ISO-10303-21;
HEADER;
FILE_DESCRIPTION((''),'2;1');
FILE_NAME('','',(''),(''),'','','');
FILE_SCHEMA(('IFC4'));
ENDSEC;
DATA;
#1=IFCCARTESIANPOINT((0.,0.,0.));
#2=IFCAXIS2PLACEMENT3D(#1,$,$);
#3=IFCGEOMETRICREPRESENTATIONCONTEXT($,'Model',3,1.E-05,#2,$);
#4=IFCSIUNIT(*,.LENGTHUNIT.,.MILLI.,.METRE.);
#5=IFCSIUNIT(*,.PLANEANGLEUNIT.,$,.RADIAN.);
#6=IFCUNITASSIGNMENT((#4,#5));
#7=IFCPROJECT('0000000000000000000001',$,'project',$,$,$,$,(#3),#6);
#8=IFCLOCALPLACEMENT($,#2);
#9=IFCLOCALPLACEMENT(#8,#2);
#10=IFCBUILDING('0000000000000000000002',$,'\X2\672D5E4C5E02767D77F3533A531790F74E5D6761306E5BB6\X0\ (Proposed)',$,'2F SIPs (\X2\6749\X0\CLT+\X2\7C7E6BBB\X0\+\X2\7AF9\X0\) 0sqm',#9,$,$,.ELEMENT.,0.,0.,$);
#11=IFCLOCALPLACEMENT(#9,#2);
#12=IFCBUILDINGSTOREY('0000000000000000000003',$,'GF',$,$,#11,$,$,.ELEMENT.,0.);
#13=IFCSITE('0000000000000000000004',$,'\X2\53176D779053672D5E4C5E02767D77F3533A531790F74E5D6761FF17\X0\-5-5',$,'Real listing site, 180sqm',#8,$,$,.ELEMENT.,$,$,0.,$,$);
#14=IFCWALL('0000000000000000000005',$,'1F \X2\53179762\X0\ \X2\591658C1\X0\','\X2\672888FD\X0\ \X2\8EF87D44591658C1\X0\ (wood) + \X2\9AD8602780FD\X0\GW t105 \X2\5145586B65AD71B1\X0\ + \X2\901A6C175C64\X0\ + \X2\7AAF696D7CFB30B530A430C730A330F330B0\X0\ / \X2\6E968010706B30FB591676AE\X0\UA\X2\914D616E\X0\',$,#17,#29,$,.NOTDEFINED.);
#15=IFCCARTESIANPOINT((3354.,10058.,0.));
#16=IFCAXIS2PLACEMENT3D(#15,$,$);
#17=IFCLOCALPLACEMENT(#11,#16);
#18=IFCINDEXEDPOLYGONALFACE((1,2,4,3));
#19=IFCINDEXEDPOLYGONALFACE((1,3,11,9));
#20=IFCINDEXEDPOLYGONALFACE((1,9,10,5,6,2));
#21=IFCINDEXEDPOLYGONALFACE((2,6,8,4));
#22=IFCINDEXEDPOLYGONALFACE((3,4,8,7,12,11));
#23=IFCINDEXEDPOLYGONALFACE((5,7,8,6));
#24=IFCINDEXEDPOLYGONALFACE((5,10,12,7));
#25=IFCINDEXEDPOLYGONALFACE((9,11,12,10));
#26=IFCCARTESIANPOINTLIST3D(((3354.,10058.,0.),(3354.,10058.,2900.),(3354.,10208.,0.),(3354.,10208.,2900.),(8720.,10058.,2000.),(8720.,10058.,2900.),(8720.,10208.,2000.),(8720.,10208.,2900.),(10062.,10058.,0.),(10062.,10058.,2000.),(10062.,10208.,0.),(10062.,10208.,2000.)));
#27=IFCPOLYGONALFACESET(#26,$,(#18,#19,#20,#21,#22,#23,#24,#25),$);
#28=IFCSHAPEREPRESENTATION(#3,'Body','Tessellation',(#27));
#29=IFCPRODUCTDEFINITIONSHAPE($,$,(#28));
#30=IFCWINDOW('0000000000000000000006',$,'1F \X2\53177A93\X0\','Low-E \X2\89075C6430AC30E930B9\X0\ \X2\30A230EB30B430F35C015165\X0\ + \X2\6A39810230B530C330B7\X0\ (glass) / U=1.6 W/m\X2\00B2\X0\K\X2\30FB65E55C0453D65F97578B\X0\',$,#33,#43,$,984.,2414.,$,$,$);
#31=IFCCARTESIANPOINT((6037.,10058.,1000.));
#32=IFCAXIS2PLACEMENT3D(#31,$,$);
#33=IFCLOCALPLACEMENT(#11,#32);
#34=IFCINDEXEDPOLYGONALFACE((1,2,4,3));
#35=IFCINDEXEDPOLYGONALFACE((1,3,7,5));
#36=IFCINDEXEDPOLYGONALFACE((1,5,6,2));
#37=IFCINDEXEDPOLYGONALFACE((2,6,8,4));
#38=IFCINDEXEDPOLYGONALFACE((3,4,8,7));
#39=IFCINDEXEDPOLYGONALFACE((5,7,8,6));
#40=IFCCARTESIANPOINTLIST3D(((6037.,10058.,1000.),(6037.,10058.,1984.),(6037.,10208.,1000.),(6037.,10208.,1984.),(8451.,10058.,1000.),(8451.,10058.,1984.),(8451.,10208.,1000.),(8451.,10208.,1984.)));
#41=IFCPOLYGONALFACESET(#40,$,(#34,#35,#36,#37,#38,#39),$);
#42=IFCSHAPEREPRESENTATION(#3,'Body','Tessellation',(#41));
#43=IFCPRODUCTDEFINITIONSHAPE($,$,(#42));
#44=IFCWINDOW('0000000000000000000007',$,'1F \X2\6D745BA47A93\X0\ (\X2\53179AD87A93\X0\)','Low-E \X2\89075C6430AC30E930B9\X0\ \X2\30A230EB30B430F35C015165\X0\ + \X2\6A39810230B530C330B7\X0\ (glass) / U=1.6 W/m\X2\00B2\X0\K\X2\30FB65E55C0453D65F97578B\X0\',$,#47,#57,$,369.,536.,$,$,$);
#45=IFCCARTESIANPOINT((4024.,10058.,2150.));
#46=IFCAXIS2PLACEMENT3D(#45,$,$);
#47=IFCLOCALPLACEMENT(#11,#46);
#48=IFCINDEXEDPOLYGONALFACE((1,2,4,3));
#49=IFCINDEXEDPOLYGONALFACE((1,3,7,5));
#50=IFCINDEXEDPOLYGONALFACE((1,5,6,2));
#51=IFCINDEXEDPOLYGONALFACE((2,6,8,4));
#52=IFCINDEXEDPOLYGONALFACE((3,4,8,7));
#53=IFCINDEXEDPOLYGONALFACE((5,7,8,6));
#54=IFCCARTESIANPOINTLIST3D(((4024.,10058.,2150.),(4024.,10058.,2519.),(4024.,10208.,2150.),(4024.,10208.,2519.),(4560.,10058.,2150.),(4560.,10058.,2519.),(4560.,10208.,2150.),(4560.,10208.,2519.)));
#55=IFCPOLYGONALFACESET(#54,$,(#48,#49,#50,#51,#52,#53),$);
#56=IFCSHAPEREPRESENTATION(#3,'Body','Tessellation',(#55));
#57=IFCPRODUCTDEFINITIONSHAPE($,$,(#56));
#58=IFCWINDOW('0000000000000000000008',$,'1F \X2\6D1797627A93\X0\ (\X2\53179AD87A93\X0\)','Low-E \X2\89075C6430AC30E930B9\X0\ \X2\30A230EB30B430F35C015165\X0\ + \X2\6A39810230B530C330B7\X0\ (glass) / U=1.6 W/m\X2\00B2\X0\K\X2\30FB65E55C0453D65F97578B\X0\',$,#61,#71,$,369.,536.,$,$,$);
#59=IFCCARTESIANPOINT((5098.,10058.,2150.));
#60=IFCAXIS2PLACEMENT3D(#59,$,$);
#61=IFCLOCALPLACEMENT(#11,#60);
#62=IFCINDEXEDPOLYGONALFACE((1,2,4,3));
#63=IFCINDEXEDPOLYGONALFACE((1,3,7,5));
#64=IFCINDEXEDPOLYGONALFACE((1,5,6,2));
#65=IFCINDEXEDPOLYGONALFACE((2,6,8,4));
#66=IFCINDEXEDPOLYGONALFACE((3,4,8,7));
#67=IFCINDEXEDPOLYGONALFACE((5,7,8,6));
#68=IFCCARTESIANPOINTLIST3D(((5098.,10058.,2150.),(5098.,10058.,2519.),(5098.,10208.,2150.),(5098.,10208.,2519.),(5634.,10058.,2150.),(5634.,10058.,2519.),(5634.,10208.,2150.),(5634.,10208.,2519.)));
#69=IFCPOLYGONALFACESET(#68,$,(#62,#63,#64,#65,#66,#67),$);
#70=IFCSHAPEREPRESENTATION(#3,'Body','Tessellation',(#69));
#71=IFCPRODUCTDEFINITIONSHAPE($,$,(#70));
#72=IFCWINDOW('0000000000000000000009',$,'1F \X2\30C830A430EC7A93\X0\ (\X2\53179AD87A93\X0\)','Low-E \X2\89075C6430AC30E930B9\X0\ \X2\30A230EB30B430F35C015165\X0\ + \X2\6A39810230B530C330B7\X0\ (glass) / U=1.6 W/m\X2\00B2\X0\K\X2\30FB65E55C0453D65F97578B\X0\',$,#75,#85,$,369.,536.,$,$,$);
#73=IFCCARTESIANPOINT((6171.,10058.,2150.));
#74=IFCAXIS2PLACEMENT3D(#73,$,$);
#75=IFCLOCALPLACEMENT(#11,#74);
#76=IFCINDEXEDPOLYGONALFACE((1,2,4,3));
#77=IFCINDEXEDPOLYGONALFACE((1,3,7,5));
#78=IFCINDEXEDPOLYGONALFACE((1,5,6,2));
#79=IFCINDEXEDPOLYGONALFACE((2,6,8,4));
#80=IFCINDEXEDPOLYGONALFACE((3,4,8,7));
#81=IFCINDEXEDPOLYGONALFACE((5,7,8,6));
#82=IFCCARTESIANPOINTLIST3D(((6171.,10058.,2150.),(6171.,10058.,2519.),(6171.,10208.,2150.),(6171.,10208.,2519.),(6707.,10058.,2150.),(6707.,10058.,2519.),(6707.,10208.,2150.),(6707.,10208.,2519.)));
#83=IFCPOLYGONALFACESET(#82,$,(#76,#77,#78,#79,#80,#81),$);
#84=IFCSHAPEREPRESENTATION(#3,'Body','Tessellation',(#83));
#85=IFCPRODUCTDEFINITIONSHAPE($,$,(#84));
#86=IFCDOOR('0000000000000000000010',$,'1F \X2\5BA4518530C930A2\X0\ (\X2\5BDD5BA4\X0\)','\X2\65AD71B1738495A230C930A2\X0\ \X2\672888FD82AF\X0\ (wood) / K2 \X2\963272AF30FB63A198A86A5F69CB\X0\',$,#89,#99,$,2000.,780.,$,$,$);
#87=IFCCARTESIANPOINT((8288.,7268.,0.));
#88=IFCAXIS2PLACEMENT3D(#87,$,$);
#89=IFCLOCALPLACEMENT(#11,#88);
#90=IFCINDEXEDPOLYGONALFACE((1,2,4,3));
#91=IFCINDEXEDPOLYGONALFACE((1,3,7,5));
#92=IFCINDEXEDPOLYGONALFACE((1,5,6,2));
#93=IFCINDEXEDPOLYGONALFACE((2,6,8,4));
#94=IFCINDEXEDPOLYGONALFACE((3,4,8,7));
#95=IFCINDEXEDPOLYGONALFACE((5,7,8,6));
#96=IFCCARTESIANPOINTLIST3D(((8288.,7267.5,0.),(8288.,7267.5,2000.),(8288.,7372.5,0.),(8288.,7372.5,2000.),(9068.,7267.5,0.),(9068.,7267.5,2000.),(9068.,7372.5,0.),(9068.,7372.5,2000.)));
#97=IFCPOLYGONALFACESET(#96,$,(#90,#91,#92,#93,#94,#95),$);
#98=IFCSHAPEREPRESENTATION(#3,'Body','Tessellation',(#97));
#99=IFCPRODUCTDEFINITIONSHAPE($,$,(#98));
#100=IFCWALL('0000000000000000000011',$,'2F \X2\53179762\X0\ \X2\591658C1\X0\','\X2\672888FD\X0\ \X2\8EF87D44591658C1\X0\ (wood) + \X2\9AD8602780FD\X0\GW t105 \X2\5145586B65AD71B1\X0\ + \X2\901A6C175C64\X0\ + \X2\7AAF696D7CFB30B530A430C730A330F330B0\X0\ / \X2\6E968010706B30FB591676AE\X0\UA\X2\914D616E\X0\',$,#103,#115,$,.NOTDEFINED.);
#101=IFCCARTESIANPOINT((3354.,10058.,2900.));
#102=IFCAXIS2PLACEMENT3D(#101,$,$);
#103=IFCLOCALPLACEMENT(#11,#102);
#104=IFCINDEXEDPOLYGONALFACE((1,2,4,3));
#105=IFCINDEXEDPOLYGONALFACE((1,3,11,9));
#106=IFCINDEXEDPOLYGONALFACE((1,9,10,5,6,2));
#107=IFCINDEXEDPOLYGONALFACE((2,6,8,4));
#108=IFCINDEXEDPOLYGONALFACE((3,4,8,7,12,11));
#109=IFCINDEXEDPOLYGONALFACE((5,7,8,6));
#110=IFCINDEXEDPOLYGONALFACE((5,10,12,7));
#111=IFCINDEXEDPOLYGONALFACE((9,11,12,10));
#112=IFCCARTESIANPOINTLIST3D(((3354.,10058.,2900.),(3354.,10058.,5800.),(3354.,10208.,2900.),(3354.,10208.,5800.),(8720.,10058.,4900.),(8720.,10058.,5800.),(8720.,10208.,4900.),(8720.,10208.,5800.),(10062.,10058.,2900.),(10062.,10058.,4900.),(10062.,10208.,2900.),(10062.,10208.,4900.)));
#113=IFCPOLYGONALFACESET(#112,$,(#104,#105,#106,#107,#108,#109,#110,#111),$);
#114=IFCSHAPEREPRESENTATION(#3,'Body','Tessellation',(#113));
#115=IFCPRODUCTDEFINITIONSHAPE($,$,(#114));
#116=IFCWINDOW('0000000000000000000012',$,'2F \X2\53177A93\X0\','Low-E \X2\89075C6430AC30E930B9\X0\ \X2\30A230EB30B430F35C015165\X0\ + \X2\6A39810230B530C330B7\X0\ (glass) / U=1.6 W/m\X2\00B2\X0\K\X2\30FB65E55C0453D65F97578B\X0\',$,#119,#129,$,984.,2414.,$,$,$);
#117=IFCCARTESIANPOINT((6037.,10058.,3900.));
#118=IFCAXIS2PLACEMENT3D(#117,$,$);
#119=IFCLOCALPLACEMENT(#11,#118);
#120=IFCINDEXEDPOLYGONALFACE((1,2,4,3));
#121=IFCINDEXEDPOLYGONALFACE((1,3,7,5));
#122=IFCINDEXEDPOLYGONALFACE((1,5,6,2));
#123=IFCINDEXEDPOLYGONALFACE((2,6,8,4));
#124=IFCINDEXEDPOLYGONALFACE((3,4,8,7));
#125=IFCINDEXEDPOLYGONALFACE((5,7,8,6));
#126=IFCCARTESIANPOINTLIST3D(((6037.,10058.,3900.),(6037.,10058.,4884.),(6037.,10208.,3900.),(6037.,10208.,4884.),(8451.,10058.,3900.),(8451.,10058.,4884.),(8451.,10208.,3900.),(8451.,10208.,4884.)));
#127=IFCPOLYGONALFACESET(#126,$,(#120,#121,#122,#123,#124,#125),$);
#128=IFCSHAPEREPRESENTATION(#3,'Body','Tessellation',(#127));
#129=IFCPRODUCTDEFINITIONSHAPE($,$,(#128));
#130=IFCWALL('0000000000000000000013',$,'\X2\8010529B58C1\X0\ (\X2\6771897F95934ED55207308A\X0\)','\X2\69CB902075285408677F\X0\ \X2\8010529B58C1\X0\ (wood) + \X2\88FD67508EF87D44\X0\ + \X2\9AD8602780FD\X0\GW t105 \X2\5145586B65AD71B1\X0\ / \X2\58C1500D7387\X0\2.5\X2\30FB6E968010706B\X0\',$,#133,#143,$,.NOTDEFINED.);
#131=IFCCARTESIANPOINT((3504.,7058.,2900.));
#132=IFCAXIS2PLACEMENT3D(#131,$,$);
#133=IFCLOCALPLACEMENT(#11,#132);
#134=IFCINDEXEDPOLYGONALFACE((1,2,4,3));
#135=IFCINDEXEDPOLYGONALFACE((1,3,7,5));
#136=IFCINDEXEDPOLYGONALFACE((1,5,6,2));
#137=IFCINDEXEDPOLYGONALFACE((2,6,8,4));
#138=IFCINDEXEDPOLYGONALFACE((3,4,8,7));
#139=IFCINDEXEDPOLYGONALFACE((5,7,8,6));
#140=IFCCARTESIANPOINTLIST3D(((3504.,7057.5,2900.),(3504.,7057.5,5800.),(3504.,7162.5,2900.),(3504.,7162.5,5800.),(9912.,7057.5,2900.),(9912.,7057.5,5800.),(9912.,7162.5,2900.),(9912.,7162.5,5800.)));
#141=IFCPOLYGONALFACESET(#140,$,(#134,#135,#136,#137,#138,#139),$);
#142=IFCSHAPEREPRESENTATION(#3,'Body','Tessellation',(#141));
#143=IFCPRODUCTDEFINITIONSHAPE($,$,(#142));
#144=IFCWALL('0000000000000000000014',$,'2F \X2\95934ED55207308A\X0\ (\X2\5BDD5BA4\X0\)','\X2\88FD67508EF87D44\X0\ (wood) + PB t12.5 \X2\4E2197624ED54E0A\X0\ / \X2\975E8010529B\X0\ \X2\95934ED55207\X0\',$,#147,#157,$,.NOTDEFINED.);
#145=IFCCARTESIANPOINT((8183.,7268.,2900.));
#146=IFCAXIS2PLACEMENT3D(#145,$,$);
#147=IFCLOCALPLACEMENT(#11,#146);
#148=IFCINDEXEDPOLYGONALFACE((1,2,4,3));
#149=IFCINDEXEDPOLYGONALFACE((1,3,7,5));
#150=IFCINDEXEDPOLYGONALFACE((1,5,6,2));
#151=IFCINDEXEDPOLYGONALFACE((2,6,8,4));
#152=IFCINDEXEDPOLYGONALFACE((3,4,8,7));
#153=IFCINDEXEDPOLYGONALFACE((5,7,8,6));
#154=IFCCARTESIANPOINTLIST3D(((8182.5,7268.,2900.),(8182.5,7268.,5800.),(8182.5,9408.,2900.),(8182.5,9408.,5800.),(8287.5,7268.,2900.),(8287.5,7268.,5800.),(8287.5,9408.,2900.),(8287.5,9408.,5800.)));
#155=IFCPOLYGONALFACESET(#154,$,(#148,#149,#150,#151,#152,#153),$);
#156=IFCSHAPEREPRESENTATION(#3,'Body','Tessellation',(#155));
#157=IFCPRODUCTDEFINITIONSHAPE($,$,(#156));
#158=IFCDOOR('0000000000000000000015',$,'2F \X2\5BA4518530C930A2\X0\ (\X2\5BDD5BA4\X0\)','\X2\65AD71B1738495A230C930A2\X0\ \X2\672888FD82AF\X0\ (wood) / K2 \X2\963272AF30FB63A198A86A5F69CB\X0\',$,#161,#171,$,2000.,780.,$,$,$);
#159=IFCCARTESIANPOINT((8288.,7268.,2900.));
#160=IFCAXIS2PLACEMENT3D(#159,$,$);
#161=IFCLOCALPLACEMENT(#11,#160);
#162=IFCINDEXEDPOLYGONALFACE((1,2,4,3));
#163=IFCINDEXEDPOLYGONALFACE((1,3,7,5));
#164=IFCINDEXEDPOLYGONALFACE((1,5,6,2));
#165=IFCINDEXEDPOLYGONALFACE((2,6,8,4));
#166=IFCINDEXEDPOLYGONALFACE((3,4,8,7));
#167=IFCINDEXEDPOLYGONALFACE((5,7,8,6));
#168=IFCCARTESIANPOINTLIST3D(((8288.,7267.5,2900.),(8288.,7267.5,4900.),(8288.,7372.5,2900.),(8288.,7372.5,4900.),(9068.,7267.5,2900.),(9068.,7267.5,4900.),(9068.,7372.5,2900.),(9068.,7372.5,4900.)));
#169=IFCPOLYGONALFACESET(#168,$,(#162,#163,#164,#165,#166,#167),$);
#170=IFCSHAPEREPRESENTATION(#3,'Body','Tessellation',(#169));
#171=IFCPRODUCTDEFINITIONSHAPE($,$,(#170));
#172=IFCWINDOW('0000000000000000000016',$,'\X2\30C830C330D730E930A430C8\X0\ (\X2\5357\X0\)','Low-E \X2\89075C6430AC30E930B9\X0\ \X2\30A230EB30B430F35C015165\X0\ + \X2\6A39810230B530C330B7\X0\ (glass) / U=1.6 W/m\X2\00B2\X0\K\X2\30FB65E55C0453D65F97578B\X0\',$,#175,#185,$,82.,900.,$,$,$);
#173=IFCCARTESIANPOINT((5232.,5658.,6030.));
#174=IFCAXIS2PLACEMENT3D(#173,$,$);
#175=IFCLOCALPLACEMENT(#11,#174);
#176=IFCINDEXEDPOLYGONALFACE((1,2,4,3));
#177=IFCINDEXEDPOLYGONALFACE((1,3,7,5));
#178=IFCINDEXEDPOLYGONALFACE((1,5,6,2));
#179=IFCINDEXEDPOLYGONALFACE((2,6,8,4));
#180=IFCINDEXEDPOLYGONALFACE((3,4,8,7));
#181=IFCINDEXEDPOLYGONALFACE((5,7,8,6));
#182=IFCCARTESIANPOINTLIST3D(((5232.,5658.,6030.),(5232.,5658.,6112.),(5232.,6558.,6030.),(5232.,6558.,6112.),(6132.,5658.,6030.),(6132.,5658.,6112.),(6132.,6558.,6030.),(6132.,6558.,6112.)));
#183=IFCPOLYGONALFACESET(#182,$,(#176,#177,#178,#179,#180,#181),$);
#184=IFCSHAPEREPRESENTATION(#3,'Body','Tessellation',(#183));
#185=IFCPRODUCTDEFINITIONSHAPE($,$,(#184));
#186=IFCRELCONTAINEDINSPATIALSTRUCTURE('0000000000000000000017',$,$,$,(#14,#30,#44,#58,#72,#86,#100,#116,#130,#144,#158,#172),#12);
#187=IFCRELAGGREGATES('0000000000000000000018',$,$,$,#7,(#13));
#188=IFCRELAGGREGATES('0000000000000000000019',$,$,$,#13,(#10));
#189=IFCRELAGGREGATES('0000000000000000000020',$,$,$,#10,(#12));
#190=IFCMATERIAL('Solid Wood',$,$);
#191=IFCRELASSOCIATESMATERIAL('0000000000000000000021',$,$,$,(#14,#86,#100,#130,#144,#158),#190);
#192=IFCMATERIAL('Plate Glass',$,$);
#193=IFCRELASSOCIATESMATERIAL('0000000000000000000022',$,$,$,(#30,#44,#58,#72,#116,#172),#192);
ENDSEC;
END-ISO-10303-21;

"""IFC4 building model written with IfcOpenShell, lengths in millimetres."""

from ifc_helpers import new_model, si_unit, frame, frame_2d, origin, place, context, project, spatial, rectangle, extrude, material, element, fill, save


model = new_model("IFC4")

# Units and contexts
model_context = context("Model", 3, precision=1e-05, world=origin())
ifc_project = project(units=[si_unit("LENGTHUNIT", "METRE", prefix="MILLI"), si_unit("PLANEANGLEUNIT", "RADIAN")], contexts=[model_context])

# Site, building, storey
site_placement = place(None, origin())
site = spatial("IfcSite", under=ifc_project, at=site_placement, Name="北海道札幌市白石区北郷九条７-5-5", ObjectType="Real listing site, 180sqm", CompositionType="ELEMENT", RefElevation=0.0)
building_placement = place(site_placement, origin())
building = spatial("IfcBuilding", under=site, at=building_placement, Name="札幌市白石区北郷九条の家 (Proposed)", ObjectType="2F SIPs (杉CLT+籾殻+竹) 0sqm", CompositionType="ELEMENT", ElevationOfRefHeight=0.0, ElevationOfTerrain=0.0)
storey_placement = place(building_placement, origin())
storey = spatial("IfcBuildingStorey", under=building, at=storey_placement, Name="GF", CompositionType="ELEMENT", Elevation=0.0)

# Wall, openings, windows
ifc_material_1 = material(Name="Solid Wood")
wall_1_placement = place(storey_placement, frame((3354.0, 10058.0, 0.0)))
wall_1 = element("IfcWall", 1, at=wall_1_placement, inside=storey, material=ifc_material_1, Name="1F 北面 外壁", Description="木製 軸組外壁 (wood) + 高性能GW t105 充填断熱 + 通気層 + 窯業系サイディング / 準耐火・外皮UA配慮", PredefinedType="NOTDEFINED", context=model_context, shape_type="SweptSolid", body=[
    extrude(rectangle(XDim=6708.0, YDim=150.0, at=frame_2d((3354.0, 75.0))), frame((3354.0, 10058.0, 0.0)), (0.0, 0.0, 1.0), 2900.0),
])
opening_1_placement = place(storey_placement, frame((6037.0, 10058.0, 1000.0)))
opening_1 = element("IfcOpeningElement", 2, at=opening_1_placement, cuts=wall_1, PredefinedType="NOTDEFINED", context=model_context, shape_type="SweptSolid", body=[
    extrude(rectangle(XDim=2414.0, YDim=150.0, at=frame_2d((1207.0, 75.0))), frame((6037.0, 10058.0, 1000.0)), (0.0, 0.0, 1.0), 984.0),
])
opening_2_placement = place(storey_placement, frame((4024.0, 10058.0, 2150.0)))
opening_2 = element("IfcOpeningElement", 3, at=opening_2_placement, cuts=wall_1, PredefinedType="NOTDEFINED", context=model_context, shape_type="SweptSolid", body=[
    extrude(rectangle(XDim=536.0, YDim=150.0, at=frame_2d((268.0, 75.0))), frame((4024.0, 10058.0, 2150.0)), (0.0, 0.0, 1.0), 369.0),
])
opening_3_placement = place(storey_placement, frame((5098.0, 10058.0, 2150.0)))
opening_3 = element("IfcOpeningElement", 4, at=opening_3_placement, cuts=wall_1, PredefinedType="NOTDEFINED", context=model_context, shape_type="SweptSolid", body=[
    extrude(rectangle(XDim=536.0, YDim=150.0, at=frame_2d((268.0, 75.0))), frame((5098.0, 10058.0, 2150.0)), (0.0, 0.0, 1.0), 369.0),
])
opening_4_placement = place(storey_placement, frame((6171.0, 10058.0, 2150.0)))
opening_4 = element("IfcOpeningElement", 5, at=opening_4_placement, cuts=wall_1, PredefinedType="NOTDEFINED", context=model_context, shape_type="SweptSolid", body=[
    extrude(rectangle(XDim=536.0, YDim=150.0, at=frame_2d((268.0, 75.0))), frame((6171.0, 10058.0, 2150.0)), (0.0, 0.0, 1.0), 369.0),
])
ifc_material_2 = material(Name="Plate Glass")
window_1_placement = place(storey_placement, frame((6037.0, 10058.0, 1000.0)))
window_1 = element("IfcWindow", 6, at=window_1_placement, inside=storey, material=ifc_material_2, Name="1F 北窓", Description="Low-E 複層ガラス アルゴン封入 + 樹脂サッシ (glass) / U=1.6 W/m²K・日射取得型", OverallHeight=984.0, OverallWidth=2414.0, context=model_context, shape_type="SweptSolid", body=[
    extrude(rectangle(XDim=2414.0, YDim=150.0, at=frame_2d((1207.0, 75.0))), frame((6037.0, 10058.0, 1000.0)), (0.0, 0.0, 1.0), 984.0),
])
fill(opening_1, window_1)
window_2_placement = place(storey_placement, frame((4024.0, 10058.0, 2150.0)))
window_2 = element("IfcWindow", 7, at=window_2_placement, inside=storey, material=ifc_material_2, Name="1F 浴室窓 (北高窓)", Description="Low-E 複層ガラス アルゴン封入 + 樹脂サッシ (glass) / U=1.6 W/m²K・日射取得型", OverallHeight=369.0, OverallWidth=536.0, context=model_context, shape_type="SweptSolid", body=[
    extrude(rectangle(XDim=536.0, YDim=150.0, at=frame_2d((268.0, 75.0))), frame((4024.0, 10058.0, 2150.0)), (0.0, 0.0, 1.0), 369.0),
])
fill(opening_2, window_2)
window_3_placement = place(storey_placement, frame((5098.0, 10058.0, 2150.0)))
window_3 = element("IfcWindow", 8, at=window_3_placement, inside=storey, material=ifc_material_2, Name="1F 洗面窓 (北高窓)", Description="Low-E 複層ガラス アルゴン封入 + 樹脂サッシ (glass) / U=1.6 W/m²K・日射取得型", OverallHeight=369.0, OverallWidth=536.0, context=model_context, shape_type="SweptSolid", body=[
    extrude(rectangle(XDim=536.0, YDim=150.0, at=frame_2d((268.0, 75.0))), frame((5098.0, 10058.0, 2150.0)), (0.0, 0.0, 1.0), 369.0),
])
fill(opening_3, window_3)
window_4_placement = place(storey_placement, frame((6171.0, 10058.0, 2150.0)))
window_4 = element("IfcWindow", 9, at=window_4_placement, inside=storey, material=ifc_material_2, Name="1F トイレ窓 (北高窓)", Description="Low-E 複層ガラス アルゴン封入 + 樹脂サッシ (glass) / U=1.6 W/m²K・日射取得型", OverallHeight=369.0, OverallWidth=536.0, context=model_context, shape_type="SweptSolid", body=[
    extrude(rectangle(XDim=536.0, YDim=150.0, at=frame_2d((268.0, 75.0))), frame((6171.0, 10058.0, 2150.0)), (0.0, 0.0, 1.0), 369.0),
])
fill(opening_4, window_4)

# Door
door_1_placement = place(storey_placement, frame((8288.0, 7268.0, 0.0)))
element("IfcDoor", 10, at=door_1_placement, inside=storey, material=ifc_material_1, Name="1F 室内ドア (寝室)", Description="断熱玄関ドア 木製芯 (wood) / K2 防犯・採風機構", OverallHeight=2000.0, OverallWidth=780.0, context=model_context, shape_type="SweptSolid", body=[
    extrude(rectangle(XDim=780.0, YDim=105.0, at=frame_2d((390.0, 52.0))), frame((8288.0, 7268.0, 0.0)), (0.0, 0.0, 1.0), 2000.0),
])

# Wall, opening, window
wall_2_placement = place(storey_placement, frame((3354.0, 10058.0, 2900.0)))
wall_2 = element("IfcWall", 11, at=wall_2_placement, inside=storey, material=ifc_material_1, Name="2F 北面 外壁", Description="木製 軸組外壁 (wood) + 高性能GW t105 充填断熱 + 通気層 + 窯業系サイディング / 準耐火・外皮UA配慮", PredefinedType="NOTDEFINED", context=model_context, shape_type="SweptSolid", body=[
    extrude(rectangle(XDim=6708.0, YDim=150.0, at=frame_2d((3354.0, 75.0))), frame((3354.0, 10058.0, 2900.0)), (0.0, 0.0, 1.0), 2900.0),
])
opening_5_placement = place(storey_placement, frame((6037.0, 10058.0, 3900.0)))
opening_5 = element("IfcOpeningElement", 12, at=opening_5_placement, cuts=wall_2, PredefinedType="NOTDEFINED", context=model_context, shape_type="SweptSolid", body=[
    extrude(rectangle(XDim=2414.0, YDim=150.0, at=frame_2d((1207.0, 75.0))), frame((6037.0, 10058.0, 3900.0)), (0.0, 0.0, 1.0), 984.0),
])
window_5_placement = place(storey_placement, frame((6037.0, 10058.0, 3900.0)))
window_5 = element("IfcWindow", 13, at=window_5_placement, inside=storey, material=ifc_material_2, Name="2F 北窓", Description="Low-E 複層ガラス アルゴン封入 + 樹脂サッシ (glass) / U=1.6 W/m²K・日射取得型", OverallHeight=984.0, OverallWidth=2414.0, context=model_context, shape_type="SweptSolid", body=[
    extrude(rectangle(XDim=2414.0, YDim=150.0, at=frame_2d((1207.0, 75.0))), frame((6037.0, 10058.0, 3900.0)), (0.0, 0.0, 1.0), 984.0),
])
fill(opening_5, window_5)

# Walls
wall_3_placement = place(storey_placement, frame((3504.0, 7058.0, 2900.0)))
element("IfcWall", 14, at=wall_3_placement, inside=storey, material=ifc_material_1, Name="耐力壁 (東西間仕切り)", Description="構造用合板 耐力壁 (wood) + 製材軸組 + 高性能GW t105 充填断熱 / 壁倍率2.5・準耐火", PredefinedType="NOTDEFINED", context=model_context, shape_type="SweptSolid", body=[
    extrude(rectangle(XDim=6408.0, YDim=105.0, at=frame_2d((3204.0, 52.0))), frame((3504.0, 7058.0, 2900.0)), (0.0, 0.0, 1.0), 2900.0),
])
wall_4_placement = place(storey_placement, frame((8183.0, 7268.0, 2900.0)))
element("IfcWall", 15, at=wall_4_placement, inside=storey, material=ifc_material_1, Name="2F 間仕切り (寝室)", Description="製材軸組 (wood) + PB t12.5 両面仕上 / 非耐力 間仕切", PredefinedType="NOTDEFINED", context=model_context, shape_type="SweptSolid", body=[
    extrude(rectangle(XDim=105.0, YDim=2140.0, at=frame_2d((52.0, 1070.0))), frame((8183.0, 7268.0, 2900.0)), (0.0, 0.0, 1.0), 2900.0),
])

# Door
door_2_placement = place(storey_placement, frame((8288.0, 7268.0, 2900.0)))
element("IfcDoor", 16, at=door_2_placement, inside=storey, material=ifc_material_1, Name="2F 室内ドア (寝室)", Description="断熱玄関ドア 木製芯 (wood) / K2 防犯・採風機構", OverallHeight=2000.0, OverallWidth=780.0, context=model_context, shape_type="SweptSolid", body=[
    extrude(rectangle(XDim=780.0, YDim=105.0, at=frame_2d((390.0, 52.0))), frame((8288.0, 7268.0, 2900.0)), (0.0, 0.0, 1.0), 2000.0),
])

# Window
window_6_placement = place(storey_placement, frame((5232.0, 5658.0, 6030.0)))
element("IfcWindow", 17, at=window_6_placement, inside=storey, material=ifc_material_2, Name="トップライト (南)", Description="Low-E 複層ガラス アルゴン封入 + 樹脂サッシ (glass) / U=1.6 W/m²K・日射取得型", OverallHeight=82.0, OverallWidth=900.0, context=model_context, shape_type="SweptSolid", body=[
    extrude(rectangle(XDim=900.0, YDim=900.0, at=frame_2d((450.0, 450.0))), frame((5232.0, 5658.0, 6030.0)), (0.0, 0.0, 1.0), 82.0),
])

save(model, "model.ifc")
